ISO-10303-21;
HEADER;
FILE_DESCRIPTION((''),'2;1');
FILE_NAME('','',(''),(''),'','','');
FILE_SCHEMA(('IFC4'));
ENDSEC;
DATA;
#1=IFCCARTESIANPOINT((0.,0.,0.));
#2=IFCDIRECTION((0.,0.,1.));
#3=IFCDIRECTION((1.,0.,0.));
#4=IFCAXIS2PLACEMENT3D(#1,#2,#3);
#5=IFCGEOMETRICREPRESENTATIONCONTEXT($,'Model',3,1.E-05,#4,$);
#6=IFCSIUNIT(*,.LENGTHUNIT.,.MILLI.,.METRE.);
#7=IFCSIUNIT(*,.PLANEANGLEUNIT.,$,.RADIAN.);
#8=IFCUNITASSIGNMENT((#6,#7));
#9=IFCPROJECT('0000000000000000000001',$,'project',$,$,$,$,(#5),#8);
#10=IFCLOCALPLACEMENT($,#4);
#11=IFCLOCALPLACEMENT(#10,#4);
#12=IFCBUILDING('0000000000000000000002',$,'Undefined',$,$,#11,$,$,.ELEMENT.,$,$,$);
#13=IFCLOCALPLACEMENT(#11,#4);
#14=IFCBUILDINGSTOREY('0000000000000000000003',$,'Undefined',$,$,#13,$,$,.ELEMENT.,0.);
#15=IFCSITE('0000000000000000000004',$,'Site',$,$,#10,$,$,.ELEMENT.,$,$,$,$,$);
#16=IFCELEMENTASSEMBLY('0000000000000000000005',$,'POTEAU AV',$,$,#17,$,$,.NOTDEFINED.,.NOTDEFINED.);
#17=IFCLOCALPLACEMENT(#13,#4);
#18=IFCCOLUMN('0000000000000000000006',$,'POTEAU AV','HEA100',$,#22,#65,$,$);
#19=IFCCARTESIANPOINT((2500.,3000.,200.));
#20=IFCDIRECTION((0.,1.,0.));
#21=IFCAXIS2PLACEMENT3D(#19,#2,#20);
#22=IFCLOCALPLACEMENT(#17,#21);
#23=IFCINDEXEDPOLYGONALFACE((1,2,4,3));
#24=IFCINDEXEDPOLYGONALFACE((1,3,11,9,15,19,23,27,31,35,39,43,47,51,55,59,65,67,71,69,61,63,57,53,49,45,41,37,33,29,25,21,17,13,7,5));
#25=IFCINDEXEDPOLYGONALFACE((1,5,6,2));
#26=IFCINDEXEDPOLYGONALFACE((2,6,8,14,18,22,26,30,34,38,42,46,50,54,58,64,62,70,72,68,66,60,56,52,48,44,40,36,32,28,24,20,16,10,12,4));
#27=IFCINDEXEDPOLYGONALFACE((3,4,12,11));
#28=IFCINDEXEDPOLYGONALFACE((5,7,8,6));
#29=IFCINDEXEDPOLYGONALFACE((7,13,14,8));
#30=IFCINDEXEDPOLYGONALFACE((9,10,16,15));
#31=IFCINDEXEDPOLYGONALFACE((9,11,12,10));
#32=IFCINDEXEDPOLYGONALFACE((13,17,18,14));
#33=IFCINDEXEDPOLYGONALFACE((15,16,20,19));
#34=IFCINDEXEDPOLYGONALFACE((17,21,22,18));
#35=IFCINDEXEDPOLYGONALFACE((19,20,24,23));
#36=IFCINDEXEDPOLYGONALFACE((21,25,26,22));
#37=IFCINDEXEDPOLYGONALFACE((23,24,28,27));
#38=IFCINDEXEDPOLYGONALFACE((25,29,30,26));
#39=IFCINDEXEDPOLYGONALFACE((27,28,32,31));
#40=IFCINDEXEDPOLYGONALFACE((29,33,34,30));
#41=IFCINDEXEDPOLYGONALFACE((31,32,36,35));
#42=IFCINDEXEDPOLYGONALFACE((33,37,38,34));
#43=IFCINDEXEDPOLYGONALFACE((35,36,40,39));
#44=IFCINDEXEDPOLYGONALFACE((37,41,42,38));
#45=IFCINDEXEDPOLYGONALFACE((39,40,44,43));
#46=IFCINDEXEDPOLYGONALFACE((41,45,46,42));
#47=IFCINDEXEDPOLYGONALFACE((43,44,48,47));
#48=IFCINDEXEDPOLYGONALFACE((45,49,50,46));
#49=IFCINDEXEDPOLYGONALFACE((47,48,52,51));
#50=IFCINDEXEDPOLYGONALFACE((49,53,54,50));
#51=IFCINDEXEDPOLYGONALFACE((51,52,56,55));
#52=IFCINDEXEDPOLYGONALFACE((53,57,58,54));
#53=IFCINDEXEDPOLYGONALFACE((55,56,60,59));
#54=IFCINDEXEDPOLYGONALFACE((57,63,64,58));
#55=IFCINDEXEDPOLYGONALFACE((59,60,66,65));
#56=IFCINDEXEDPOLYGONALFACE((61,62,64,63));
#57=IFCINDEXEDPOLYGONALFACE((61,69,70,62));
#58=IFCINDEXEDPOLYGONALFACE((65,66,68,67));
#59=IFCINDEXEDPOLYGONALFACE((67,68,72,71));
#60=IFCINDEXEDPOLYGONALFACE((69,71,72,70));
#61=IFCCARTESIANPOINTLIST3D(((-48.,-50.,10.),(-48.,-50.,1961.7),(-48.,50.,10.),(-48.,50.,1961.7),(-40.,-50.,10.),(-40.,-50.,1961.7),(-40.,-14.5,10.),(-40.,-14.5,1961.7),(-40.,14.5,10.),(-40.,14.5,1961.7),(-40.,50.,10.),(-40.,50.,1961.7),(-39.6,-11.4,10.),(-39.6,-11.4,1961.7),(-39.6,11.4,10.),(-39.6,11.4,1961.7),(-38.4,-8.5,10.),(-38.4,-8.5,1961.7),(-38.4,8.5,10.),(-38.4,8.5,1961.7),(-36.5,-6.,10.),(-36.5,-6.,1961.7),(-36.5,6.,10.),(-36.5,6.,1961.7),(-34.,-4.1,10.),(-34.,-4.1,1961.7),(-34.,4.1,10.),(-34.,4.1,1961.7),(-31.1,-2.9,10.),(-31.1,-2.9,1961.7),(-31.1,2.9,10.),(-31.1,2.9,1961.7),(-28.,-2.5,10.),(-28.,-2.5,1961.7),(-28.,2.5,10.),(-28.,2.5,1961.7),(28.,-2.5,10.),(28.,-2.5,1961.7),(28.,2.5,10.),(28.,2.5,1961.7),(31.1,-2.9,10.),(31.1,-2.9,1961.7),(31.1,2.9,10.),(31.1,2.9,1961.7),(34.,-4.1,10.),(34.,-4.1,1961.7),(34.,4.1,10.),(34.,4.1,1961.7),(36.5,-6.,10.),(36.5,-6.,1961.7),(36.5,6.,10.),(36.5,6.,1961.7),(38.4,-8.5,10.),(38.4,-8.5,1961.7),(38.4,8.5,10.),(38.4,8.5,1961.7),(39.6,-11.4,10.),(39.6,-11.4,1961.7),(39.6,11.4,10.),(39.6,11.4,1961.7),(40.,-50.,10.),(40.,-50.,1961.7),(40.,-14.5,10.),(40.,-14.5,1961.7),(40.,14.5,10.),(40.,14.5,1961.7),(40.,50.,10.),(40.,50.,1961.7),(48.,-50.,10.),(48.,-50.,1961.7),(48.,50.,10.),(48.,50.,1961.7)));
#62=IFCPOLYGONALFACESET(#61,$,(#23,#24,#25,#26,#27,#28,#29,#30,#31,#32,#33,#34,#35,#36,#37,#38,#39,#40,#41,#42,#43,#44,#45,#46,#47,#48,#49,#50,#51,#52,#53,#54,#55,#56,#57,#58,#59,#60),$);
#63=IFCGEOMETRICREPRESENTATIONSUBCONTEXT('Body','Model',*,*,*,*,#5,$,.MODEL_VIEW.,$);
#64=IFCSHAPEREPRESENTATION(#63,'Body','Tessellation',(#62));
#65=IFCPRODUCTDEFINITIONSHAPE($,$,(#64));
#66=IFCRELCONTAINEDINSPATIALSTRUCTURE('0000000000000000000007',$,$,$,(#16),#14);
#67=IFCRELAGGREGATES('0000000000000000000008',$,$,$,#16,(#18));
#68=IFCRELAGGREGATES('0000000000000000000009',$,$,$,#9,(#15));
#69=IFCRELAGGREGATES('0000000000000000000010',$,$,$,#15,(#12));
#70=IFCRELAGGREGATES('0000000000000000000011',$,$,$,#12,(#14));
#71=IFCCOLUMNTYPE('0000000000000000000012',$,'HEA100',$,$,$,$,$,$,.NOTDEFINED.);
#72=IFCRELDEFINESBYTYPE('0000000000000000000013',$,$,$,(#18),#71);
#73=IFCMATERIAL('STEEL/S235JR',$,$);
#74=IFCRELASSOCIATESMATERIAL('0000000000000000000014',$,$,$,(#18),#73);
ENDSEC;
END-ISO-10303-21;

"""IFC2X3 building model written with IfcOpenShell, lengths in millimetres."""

from ifc_helpers import new_model, si_unit, frame, origin_with_axes, origin_2d_with_axis, place, context, subcontext, project, spatial, i_section, extrude, clip, halfspace, material, type_object, element, aggregate, save


model = new_model("IFC2X3")

# Units and contexts
model_context = context("Model", 3, precision=1e-05, world=origin_with_axes())
body_context = subcontext(model_context, "Body", "Model", "MODEL_VIEW")
ifc_project = project(units=[si_unit("LENGTHUNIT", "METRE", prefix="MILLI"), si_unit("PLANEANGLEUNIT", "RADIAN")], contexts=[model_context])

# Site, building, storey
site_placement = place(None, origin_with_axes())
site = spatial("IfcSite", under=ifc_project, at=site_placement, Name="Site", CompositionType="ELEMENT")
building_placement = place(site_placement, origin_with_axes())
building = spatial("IfcBuilding", under=site, at=building_placement, Name="Undefined", CompositionType="ELEMENT")
storey_placement = place(building_placement, origin_with_axes())
storey = spatial("IfcBuildingStorey", under=building, at=storey_placement, Name="Undefined", CompositionType="ELEMENT", Elevation=0.0)

# Element assembly, column
ifc_material_1 = material(Name="STEEL/S235JR")
assembly_1_placement = place(storey_placement, origin_with_axes())
assembly_1 = element("IfcElementAssembly", 1, at=assembly_1_placement, inside=storey, Name="POTEAU AV", AssemblyPlace="NOTDEFINED", PredefinedType="NOTDEFINED")
column_type_1 = type_object("IfcColumnType", Name="HEA100", PredefinedType="NOTDEFINED")
column_1_placement = place(assembly_1_placement, frame((2500.0, 3000.0, 200.0), z_axis=(0.0, 0.0, 1.0), x_axis=(0.0, 1.0, 0.0)))
column_1 = element("IfcColumn", 2, at=column_1_placement, type_object=column_type_1, material=ifc_material_1, Name="POTEAU AV", Description="HEA100", context=body_context, shape_type="Clipping", body=[
    clip(clip(extrude(i_section(OverallWidth=100.0, OverallDepth=96.0, WebThickness=5.0, FlangeThickness=8.0, FilletRadius=12.0, at=origin_2d_with_axis()), frame((0.0, 0.0, 2000.0), z_axis=(0.0, 0.0, -1.0), x_axis=(0.0, 1.0, 0.0)), (0.0, 0.0, 1.0), 2000.0), halfspace(frame((48.0, 0.0, 1961.7), z_axis=(0.0, 0.0, -1.0), x_axis=(0.0, 1.0, 0.0)), True)), halfspace(frame((-48.0, 0.0, 10.0), z_axis=(0.0, 0.0, 1.0), x_axis=(0.0, 1.0, 0.0)), True)),
])

aggregate(assembly_1, [column_1])

save(model, "model.ifc")
